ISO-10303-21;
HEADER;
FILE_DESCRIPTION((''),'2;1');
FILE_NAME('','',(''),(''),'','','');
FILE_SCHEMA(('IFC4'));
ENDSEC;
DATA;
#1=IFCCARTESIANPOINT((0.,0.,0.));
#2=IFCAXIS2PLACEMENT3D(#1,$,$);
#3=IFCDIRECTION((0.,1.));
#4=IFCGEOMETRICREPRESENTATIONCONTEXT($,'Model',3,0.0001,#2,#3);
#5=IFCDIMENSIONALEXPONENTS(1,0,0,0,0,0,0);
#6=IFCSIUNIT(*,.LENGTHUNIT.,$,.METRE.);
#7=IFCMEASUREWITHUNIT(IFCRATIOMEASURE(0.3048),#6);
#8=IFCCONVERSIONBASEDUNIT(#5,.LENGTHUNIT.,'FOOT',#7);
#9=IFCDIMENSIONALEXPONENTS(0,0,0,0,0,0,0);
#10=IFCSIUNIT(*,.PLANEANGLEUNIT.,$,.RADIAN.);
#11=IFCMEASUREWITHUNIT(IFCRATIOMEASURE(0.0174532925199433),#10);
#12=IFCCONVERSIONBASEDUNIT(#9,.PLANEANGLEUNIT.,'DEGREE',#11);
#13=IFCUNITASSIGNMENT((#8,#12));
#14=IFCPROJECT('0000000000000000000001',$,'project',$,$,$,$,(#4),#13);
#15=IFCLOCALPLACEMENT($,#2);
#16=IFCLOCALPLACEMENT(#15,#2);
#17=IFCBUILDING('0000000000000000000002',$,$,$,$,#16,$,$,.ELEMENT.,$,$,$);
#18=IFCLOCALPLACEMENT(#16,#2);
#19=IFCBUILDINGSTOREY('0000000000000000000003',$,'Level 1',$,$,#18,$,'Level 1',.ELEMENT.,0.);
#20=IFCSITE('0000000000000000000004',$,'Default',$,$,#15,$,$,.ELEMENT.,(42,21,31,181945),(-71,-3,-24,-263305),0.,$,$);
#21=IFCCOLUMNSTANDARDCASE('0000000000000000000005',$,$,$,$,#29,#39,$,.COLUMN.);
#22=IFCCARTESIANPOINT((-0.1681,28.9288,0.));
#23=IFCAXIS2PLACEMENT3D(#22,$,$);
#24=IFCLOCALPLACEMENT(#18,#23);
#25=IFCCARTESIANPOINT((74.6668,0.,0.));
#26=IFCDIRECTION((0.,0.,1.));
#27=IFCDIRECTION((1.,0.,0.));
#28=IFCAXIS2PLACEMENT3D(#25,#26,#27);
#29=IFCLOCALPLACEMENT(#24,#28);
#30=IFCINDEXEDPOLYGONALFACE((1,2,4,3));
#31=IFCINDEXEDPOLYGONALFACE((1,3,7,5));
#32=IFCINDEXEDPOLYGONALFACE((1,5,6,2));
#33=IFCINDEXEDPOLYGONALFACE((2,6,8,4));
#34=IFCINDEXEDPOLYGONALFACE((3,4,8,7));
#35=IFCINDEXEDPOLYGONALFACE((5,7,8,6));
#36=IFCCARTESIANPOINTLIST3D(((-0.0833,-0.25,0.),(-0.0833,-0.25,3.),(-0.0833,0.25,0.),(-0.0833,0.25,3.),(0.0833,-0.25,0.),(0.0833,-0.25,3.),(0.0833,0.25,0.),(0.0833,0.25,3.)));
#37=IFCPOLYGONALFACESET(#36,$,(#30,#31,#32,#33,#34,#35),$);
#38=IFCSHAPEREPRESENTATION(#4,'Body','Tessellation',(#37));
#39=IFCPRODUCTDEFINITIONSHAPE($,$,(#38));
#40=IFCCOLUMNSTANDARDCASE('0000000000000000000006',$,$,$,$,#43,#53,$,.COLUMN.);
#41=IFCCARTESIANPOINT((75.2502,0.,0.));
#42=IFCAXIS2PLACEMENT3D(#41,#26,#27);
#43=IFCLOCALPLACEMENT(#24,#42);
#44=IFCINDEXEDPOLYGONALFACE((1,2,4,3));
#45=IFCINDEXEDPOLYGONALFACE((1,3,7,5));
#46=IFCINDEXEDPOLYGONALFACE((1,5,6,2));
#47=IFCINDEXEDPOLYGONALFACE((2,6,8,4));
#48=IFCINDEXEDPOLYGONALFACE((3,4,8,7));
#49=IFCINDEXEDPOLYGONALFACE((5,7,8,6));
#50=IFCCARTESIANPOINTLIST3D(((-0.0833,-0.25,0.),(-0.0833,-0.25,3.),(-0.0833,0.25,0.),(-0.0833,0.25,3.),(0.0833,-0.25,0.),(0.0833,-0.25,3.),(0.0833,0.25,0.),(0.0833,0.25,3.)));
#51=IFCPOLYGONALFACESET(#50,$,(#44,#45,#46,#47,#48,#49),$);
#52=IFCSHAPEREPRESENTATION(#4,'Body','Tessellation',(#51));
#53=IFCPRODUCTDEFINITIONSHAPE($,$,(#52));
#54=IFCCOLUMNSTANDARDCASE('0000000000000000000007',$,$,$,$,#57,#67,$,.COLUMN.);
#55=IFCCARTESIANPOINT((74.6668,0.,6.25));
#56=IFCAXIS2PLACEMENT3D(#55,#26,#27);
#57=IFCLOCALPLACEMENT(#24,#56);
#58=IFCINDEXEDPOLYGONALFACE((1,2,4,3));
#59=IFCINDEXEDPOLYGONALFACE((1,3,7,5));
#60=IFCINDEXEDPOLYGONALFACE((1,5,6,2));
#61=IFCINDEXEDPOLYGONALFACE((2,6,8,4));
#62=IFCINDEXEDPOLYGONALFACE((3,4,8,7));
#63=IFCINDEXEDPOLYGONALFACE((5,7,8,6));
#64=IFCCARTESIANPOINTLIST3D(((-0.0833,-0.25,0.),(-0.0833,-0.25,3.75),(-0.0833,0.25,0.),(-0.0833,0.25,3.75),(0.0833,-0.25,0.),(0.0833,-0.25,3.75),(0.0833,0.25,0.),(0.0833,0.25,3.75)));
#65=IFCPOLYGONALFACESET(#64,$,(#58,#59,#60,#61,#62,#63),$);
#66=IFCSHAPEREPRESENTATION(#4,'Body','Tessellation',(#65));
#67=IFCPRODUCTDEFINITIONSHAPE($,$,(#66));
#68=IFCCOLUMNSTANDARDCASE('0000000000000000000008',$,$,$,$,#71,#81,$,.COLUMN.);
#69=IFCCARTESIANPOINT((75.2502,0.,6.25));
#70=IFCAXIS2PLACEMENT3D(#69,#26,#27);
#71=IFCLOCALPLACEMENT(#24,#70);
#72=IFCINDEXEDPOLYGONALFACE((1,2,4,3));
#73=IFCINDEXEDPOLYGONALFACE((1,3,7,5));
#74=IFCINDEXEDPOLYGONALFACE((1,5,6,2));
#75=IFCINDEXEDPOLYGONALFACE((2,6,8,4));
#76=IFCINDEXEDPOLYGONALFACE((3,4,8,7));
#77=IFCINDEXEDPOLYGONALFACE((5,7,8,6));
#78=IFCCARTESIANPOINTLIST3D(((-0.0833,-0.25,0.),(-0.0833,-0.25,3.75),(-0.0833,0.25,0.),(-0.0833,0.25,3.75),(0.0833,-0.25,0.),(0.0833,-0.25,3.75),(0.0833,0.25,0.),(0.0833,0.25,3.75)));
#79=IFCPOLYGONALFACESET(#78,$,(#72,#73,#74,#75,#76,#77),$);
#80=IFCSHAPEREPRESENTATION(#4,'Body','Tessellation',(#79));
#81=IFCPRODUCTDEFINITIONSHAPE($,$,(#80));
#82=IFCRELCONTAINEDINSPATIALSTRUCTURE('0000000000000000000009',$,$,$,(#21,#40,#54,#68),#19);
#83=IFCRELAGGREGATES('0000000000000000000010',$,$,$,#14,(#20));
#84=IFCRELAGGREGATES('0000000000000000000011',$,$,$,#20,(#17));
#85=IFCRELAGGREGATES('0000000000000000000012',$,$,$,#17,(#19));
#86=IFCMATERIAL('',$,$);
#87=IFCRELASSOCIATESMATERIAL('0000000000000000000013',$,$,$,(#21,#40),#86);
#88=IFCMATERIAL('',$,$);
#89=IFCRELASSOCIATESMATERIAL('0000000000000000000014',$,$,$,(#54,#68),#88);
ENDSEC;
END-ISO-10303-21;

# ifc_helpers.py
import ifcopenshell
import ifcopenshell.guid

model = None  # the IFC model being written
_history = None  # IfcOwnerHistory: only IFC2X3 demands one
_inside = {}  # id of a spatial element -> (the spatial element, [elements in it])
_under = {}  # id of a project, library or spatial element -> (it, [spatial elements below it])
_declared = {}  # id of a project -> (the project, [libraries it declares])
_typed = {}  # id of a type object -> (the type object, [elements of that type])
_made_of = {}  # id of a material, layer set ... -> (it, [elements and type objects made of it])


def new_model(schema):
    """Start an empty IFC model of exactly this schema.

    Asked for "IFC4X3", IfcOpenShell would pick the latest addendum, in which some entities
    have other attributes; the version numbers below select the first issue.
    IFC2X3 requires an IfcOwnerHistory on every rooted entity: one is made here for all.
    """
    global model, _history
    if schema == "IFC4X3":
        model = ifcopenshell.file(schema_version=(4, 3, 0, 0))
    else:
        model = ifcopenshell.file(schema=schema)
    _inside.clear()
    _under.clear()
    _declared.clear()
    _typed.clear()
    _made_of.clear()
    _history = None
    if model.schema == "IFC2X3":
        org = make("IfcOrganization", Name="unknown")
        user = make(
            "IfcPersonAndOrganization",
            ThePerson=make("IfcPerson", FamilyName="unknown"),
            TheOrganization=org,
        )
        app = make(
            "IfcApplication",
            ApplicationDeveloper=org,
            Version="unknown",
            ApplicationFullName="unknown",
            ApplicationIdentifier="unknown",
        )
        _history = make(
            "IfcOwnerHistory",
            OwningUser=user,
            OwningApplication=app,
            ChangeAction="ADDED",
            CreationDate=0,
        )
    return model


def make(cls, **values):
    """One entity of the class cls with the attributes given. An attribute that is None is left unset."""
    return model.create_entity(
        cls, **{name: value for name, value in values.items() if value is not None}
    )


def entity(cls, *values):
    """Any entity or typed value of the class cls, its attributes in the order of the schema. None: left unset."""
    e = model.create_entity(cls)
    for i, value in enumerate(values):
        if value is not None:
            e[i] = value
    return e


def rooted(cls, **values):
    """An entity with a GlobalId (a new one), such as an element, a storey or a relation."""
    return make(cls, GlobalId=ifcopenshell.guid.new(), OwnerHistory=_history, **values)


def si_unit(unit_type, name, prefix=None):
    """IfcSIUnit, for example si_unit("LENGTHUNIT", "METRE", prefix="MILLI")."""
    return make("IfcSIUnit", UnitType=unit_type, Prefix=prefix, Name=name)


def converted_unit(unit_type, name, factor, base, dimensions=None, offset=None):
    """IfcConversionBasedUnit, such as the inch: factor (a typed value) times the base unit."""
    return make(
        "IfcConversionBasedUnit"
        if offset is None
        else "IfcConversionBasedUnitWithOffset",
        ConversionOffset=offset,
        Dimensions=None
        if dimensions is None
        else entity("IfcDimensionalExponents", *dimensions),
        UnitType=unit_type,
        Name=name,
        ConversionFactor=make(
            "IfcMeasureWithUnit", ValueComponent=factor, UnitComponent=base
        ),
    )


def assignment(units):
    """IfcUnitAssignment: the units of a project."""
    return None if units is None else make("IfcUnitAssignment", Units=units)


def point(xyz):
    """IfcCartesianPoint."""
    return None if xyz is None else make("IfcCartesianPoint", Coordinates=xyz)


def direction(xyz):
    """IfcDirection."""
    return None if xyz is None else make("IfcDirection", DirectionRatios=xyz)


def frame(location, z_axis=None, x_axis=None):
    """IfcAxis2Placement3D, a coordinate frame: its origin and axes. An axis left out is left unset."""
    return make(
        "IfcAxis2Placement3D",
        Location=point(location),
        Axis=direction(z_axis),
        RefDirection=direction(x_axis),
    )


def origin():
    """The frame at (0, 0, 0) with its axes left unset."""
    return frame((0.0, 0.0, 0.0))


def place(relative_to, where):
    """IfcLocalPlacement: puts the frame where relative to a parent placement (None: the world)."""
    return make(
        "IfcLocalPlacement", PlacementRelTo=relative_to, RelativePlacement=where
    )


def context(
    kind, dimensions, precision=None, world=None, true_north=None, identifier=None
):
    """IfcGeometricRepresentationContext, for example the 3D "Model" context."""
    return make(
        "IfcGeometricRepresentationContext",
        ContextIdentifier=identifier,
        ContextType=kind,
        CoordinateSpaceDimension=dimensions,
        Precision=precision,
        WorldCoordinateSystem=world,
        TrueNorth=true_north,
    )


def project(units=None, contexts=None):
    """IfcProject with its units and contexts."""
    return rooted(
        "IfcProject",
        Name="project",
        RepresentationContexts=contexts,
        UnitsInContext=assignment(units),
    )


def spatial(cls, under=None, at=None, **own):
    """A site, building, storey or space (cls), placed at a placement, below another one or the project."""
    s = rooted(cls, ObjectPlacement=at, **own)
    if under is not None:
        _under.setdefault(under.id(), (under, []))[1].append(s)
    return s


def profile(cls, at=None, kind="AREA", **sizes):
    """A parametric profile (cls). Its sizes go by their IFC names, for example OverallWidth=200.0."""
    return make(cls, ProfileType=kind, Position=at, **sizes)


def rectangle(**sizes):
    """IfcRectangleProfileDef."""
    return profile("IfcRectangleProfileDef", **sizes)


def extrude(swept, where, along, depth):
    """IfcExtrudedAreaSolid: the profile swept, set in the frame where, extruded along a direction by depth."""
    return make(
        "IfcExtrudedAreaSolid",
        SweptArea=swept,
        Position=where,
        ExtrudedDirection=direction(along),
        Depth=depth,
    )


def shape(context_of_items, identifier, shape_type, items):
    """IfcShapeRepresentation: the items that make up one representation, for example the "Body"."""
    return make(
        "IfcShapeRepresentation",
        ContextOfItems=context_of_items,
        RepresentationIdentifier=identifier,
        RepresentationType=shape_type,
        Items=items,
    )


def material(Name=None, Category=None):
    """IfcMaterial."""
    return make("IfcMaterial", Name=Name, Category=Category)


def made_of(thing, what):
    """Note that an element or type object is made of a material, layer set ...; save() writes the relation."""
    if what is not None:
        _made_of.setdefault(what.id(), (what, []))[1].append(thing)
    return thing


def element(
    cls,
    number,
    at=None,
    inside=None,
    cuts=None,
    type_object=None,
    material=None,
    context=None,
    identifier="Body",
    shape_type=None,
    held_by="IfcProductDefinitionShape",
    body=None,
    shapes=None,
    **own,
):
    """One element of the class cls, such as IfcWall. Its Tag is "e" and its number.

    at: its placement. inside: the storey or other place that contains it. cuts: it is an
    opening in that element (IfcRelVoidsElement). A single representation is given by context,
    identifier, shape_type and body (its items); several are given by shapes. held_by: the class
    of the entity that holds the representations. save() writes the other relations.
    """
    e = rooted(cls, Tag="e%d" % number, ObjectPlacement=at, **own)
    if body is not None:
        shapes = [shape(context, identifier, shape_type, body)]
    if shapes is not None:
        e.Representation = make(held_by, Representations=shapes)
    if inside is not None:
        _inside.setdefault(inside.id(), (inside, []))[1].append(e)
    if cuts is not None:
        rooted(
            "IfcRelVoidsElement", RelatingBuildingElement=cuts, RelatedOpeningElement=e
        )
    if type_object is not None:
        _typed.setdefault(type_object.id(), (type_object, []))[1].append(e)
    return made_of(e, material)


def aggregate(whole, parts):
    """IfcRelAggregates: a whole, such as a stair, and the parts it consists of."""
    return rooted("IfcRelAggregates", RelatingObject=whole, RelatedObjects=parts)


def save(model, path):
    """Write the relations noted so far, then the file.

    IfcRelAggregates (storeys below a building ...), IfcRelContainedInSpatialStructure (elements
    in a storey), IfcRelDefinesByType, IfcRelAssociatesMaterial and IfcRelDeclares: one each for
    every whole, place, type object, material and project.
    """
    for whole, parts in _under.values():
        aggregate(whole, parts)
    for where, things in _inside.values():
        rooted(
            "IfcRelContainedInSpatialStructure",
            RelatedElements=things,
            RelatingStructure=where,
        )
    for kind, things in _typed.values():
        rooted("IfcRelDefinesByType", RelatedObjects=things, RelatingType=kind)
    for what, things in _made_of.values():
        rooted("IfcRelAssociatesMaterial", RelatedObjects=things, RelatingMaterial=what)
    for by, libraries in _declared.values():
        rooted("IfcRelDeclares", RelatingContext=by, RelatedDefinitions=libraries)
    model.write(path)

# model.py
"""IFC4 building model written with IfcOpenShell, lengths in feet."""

from ifc_helpers import new_model, entity, si_unit, converted_unit, direction, frame, origin, place, context, project, spatial, rectangle, extrude, material, element, save


model = new_model("IFC4")

# Units and contexts
model_context = context("Model", 3, precision=0.0001, world=origin(), true_north=direction((0.0, 1.0)))
ifc_project = project(units=[converted_unit("LENGTHUNIT", "FOOT", entity("IfcRatioMeasure", 0.3048), si_unit("LENGTHUNIT", "METRE"), dimensions=[1, 0, 0, 0, 0, 0, 0]), converted_unit("PLANEANGLEUNIT", "DEGREE", entity("IfcRatioMeasure", 0.0174532925199433), si_unit("PLANEANGLEUNIT", "RADIAN"), dimensions=[0, 0, 0, 0, 0, 0, 0])], contexts=[model_context])

# Site, building, storey
site_placement = place(None, origin())
site = spatial("IfcSite", under=ifc_project, at=site_placement, Name="Default", CompositionType="ELEMENT", RefLatitude=(42, 21, 31, 181945), RefLongitude=(-71, -3, -24, -263305), RefElevation=0.0)
building_placement = place(site_placement, origin())
building = spatial("IfcBuilding", under=site, at=building_placement, CompositionType="ELEMENT")
storey_placement = place(building_placement, origin())
storey = spatial("IfcBuildingStorey", under=building, at=storey_placement, Name="Level 1", LongName="Level 1", CompositionType="ELEMENT", Elevation=0.0)

# Columns
ifc_material_1 = material(Name="")
placement = place(storey_placement, frame((-0.1681, 28.9288, 0.0)))
for number, where, z_axis, x_axis in (
    (1, (74.6668, 0.0, 0.0), (0.0, 0.0, 1.0), (1.0, 0.0, 0.0)),
    (2, (75.2502, 0.0, 0.0), (0.0, 0.0, 1.0), (1.0, 0.0, 0.0)),
):
    element("IfcColumnStandardCase", number, at=place(placement, frame(where, z_axis=z_axis, x_axis=x_axis)), inside=storey, material=ifc_material_1, PredefinedType="COLUMN", context=model_context, shape_type="SweptSolid", body=[
        extrude(rectangle(XDim=0.1667, YDim=0.5), origin(), (0.0, 0.0, 1.0), 3.0),
    ])
ifc_material_2 = material(Name="")
for number, where, z_axis, x_axis in (
    (3, (74.6668, 0.0, 6.25), (0.0, 0.0, 1.0), (1.0, 0.0, 0.0)),
    (4, (75.2502, 0.0, 6.25), (0.0, 0.0, 1.0), (1.0, 0.0, 0.0)),
):
    element("IfcColumnStandardCase", number, at=place(placement, frame(where, z_axis=z_axis, x_axis=x_axis)), inside=storey, material=ifc_material_2, PredefinedType="COLUMN", context=model_context, shape_type="SweptSolid", body=[
        extrude(rectangle(XDim=0.1667, YDim=0.5), origin(), (0.0, 0.0, 1.0), 3.75),
    ])

save(model, "model.ifc")
